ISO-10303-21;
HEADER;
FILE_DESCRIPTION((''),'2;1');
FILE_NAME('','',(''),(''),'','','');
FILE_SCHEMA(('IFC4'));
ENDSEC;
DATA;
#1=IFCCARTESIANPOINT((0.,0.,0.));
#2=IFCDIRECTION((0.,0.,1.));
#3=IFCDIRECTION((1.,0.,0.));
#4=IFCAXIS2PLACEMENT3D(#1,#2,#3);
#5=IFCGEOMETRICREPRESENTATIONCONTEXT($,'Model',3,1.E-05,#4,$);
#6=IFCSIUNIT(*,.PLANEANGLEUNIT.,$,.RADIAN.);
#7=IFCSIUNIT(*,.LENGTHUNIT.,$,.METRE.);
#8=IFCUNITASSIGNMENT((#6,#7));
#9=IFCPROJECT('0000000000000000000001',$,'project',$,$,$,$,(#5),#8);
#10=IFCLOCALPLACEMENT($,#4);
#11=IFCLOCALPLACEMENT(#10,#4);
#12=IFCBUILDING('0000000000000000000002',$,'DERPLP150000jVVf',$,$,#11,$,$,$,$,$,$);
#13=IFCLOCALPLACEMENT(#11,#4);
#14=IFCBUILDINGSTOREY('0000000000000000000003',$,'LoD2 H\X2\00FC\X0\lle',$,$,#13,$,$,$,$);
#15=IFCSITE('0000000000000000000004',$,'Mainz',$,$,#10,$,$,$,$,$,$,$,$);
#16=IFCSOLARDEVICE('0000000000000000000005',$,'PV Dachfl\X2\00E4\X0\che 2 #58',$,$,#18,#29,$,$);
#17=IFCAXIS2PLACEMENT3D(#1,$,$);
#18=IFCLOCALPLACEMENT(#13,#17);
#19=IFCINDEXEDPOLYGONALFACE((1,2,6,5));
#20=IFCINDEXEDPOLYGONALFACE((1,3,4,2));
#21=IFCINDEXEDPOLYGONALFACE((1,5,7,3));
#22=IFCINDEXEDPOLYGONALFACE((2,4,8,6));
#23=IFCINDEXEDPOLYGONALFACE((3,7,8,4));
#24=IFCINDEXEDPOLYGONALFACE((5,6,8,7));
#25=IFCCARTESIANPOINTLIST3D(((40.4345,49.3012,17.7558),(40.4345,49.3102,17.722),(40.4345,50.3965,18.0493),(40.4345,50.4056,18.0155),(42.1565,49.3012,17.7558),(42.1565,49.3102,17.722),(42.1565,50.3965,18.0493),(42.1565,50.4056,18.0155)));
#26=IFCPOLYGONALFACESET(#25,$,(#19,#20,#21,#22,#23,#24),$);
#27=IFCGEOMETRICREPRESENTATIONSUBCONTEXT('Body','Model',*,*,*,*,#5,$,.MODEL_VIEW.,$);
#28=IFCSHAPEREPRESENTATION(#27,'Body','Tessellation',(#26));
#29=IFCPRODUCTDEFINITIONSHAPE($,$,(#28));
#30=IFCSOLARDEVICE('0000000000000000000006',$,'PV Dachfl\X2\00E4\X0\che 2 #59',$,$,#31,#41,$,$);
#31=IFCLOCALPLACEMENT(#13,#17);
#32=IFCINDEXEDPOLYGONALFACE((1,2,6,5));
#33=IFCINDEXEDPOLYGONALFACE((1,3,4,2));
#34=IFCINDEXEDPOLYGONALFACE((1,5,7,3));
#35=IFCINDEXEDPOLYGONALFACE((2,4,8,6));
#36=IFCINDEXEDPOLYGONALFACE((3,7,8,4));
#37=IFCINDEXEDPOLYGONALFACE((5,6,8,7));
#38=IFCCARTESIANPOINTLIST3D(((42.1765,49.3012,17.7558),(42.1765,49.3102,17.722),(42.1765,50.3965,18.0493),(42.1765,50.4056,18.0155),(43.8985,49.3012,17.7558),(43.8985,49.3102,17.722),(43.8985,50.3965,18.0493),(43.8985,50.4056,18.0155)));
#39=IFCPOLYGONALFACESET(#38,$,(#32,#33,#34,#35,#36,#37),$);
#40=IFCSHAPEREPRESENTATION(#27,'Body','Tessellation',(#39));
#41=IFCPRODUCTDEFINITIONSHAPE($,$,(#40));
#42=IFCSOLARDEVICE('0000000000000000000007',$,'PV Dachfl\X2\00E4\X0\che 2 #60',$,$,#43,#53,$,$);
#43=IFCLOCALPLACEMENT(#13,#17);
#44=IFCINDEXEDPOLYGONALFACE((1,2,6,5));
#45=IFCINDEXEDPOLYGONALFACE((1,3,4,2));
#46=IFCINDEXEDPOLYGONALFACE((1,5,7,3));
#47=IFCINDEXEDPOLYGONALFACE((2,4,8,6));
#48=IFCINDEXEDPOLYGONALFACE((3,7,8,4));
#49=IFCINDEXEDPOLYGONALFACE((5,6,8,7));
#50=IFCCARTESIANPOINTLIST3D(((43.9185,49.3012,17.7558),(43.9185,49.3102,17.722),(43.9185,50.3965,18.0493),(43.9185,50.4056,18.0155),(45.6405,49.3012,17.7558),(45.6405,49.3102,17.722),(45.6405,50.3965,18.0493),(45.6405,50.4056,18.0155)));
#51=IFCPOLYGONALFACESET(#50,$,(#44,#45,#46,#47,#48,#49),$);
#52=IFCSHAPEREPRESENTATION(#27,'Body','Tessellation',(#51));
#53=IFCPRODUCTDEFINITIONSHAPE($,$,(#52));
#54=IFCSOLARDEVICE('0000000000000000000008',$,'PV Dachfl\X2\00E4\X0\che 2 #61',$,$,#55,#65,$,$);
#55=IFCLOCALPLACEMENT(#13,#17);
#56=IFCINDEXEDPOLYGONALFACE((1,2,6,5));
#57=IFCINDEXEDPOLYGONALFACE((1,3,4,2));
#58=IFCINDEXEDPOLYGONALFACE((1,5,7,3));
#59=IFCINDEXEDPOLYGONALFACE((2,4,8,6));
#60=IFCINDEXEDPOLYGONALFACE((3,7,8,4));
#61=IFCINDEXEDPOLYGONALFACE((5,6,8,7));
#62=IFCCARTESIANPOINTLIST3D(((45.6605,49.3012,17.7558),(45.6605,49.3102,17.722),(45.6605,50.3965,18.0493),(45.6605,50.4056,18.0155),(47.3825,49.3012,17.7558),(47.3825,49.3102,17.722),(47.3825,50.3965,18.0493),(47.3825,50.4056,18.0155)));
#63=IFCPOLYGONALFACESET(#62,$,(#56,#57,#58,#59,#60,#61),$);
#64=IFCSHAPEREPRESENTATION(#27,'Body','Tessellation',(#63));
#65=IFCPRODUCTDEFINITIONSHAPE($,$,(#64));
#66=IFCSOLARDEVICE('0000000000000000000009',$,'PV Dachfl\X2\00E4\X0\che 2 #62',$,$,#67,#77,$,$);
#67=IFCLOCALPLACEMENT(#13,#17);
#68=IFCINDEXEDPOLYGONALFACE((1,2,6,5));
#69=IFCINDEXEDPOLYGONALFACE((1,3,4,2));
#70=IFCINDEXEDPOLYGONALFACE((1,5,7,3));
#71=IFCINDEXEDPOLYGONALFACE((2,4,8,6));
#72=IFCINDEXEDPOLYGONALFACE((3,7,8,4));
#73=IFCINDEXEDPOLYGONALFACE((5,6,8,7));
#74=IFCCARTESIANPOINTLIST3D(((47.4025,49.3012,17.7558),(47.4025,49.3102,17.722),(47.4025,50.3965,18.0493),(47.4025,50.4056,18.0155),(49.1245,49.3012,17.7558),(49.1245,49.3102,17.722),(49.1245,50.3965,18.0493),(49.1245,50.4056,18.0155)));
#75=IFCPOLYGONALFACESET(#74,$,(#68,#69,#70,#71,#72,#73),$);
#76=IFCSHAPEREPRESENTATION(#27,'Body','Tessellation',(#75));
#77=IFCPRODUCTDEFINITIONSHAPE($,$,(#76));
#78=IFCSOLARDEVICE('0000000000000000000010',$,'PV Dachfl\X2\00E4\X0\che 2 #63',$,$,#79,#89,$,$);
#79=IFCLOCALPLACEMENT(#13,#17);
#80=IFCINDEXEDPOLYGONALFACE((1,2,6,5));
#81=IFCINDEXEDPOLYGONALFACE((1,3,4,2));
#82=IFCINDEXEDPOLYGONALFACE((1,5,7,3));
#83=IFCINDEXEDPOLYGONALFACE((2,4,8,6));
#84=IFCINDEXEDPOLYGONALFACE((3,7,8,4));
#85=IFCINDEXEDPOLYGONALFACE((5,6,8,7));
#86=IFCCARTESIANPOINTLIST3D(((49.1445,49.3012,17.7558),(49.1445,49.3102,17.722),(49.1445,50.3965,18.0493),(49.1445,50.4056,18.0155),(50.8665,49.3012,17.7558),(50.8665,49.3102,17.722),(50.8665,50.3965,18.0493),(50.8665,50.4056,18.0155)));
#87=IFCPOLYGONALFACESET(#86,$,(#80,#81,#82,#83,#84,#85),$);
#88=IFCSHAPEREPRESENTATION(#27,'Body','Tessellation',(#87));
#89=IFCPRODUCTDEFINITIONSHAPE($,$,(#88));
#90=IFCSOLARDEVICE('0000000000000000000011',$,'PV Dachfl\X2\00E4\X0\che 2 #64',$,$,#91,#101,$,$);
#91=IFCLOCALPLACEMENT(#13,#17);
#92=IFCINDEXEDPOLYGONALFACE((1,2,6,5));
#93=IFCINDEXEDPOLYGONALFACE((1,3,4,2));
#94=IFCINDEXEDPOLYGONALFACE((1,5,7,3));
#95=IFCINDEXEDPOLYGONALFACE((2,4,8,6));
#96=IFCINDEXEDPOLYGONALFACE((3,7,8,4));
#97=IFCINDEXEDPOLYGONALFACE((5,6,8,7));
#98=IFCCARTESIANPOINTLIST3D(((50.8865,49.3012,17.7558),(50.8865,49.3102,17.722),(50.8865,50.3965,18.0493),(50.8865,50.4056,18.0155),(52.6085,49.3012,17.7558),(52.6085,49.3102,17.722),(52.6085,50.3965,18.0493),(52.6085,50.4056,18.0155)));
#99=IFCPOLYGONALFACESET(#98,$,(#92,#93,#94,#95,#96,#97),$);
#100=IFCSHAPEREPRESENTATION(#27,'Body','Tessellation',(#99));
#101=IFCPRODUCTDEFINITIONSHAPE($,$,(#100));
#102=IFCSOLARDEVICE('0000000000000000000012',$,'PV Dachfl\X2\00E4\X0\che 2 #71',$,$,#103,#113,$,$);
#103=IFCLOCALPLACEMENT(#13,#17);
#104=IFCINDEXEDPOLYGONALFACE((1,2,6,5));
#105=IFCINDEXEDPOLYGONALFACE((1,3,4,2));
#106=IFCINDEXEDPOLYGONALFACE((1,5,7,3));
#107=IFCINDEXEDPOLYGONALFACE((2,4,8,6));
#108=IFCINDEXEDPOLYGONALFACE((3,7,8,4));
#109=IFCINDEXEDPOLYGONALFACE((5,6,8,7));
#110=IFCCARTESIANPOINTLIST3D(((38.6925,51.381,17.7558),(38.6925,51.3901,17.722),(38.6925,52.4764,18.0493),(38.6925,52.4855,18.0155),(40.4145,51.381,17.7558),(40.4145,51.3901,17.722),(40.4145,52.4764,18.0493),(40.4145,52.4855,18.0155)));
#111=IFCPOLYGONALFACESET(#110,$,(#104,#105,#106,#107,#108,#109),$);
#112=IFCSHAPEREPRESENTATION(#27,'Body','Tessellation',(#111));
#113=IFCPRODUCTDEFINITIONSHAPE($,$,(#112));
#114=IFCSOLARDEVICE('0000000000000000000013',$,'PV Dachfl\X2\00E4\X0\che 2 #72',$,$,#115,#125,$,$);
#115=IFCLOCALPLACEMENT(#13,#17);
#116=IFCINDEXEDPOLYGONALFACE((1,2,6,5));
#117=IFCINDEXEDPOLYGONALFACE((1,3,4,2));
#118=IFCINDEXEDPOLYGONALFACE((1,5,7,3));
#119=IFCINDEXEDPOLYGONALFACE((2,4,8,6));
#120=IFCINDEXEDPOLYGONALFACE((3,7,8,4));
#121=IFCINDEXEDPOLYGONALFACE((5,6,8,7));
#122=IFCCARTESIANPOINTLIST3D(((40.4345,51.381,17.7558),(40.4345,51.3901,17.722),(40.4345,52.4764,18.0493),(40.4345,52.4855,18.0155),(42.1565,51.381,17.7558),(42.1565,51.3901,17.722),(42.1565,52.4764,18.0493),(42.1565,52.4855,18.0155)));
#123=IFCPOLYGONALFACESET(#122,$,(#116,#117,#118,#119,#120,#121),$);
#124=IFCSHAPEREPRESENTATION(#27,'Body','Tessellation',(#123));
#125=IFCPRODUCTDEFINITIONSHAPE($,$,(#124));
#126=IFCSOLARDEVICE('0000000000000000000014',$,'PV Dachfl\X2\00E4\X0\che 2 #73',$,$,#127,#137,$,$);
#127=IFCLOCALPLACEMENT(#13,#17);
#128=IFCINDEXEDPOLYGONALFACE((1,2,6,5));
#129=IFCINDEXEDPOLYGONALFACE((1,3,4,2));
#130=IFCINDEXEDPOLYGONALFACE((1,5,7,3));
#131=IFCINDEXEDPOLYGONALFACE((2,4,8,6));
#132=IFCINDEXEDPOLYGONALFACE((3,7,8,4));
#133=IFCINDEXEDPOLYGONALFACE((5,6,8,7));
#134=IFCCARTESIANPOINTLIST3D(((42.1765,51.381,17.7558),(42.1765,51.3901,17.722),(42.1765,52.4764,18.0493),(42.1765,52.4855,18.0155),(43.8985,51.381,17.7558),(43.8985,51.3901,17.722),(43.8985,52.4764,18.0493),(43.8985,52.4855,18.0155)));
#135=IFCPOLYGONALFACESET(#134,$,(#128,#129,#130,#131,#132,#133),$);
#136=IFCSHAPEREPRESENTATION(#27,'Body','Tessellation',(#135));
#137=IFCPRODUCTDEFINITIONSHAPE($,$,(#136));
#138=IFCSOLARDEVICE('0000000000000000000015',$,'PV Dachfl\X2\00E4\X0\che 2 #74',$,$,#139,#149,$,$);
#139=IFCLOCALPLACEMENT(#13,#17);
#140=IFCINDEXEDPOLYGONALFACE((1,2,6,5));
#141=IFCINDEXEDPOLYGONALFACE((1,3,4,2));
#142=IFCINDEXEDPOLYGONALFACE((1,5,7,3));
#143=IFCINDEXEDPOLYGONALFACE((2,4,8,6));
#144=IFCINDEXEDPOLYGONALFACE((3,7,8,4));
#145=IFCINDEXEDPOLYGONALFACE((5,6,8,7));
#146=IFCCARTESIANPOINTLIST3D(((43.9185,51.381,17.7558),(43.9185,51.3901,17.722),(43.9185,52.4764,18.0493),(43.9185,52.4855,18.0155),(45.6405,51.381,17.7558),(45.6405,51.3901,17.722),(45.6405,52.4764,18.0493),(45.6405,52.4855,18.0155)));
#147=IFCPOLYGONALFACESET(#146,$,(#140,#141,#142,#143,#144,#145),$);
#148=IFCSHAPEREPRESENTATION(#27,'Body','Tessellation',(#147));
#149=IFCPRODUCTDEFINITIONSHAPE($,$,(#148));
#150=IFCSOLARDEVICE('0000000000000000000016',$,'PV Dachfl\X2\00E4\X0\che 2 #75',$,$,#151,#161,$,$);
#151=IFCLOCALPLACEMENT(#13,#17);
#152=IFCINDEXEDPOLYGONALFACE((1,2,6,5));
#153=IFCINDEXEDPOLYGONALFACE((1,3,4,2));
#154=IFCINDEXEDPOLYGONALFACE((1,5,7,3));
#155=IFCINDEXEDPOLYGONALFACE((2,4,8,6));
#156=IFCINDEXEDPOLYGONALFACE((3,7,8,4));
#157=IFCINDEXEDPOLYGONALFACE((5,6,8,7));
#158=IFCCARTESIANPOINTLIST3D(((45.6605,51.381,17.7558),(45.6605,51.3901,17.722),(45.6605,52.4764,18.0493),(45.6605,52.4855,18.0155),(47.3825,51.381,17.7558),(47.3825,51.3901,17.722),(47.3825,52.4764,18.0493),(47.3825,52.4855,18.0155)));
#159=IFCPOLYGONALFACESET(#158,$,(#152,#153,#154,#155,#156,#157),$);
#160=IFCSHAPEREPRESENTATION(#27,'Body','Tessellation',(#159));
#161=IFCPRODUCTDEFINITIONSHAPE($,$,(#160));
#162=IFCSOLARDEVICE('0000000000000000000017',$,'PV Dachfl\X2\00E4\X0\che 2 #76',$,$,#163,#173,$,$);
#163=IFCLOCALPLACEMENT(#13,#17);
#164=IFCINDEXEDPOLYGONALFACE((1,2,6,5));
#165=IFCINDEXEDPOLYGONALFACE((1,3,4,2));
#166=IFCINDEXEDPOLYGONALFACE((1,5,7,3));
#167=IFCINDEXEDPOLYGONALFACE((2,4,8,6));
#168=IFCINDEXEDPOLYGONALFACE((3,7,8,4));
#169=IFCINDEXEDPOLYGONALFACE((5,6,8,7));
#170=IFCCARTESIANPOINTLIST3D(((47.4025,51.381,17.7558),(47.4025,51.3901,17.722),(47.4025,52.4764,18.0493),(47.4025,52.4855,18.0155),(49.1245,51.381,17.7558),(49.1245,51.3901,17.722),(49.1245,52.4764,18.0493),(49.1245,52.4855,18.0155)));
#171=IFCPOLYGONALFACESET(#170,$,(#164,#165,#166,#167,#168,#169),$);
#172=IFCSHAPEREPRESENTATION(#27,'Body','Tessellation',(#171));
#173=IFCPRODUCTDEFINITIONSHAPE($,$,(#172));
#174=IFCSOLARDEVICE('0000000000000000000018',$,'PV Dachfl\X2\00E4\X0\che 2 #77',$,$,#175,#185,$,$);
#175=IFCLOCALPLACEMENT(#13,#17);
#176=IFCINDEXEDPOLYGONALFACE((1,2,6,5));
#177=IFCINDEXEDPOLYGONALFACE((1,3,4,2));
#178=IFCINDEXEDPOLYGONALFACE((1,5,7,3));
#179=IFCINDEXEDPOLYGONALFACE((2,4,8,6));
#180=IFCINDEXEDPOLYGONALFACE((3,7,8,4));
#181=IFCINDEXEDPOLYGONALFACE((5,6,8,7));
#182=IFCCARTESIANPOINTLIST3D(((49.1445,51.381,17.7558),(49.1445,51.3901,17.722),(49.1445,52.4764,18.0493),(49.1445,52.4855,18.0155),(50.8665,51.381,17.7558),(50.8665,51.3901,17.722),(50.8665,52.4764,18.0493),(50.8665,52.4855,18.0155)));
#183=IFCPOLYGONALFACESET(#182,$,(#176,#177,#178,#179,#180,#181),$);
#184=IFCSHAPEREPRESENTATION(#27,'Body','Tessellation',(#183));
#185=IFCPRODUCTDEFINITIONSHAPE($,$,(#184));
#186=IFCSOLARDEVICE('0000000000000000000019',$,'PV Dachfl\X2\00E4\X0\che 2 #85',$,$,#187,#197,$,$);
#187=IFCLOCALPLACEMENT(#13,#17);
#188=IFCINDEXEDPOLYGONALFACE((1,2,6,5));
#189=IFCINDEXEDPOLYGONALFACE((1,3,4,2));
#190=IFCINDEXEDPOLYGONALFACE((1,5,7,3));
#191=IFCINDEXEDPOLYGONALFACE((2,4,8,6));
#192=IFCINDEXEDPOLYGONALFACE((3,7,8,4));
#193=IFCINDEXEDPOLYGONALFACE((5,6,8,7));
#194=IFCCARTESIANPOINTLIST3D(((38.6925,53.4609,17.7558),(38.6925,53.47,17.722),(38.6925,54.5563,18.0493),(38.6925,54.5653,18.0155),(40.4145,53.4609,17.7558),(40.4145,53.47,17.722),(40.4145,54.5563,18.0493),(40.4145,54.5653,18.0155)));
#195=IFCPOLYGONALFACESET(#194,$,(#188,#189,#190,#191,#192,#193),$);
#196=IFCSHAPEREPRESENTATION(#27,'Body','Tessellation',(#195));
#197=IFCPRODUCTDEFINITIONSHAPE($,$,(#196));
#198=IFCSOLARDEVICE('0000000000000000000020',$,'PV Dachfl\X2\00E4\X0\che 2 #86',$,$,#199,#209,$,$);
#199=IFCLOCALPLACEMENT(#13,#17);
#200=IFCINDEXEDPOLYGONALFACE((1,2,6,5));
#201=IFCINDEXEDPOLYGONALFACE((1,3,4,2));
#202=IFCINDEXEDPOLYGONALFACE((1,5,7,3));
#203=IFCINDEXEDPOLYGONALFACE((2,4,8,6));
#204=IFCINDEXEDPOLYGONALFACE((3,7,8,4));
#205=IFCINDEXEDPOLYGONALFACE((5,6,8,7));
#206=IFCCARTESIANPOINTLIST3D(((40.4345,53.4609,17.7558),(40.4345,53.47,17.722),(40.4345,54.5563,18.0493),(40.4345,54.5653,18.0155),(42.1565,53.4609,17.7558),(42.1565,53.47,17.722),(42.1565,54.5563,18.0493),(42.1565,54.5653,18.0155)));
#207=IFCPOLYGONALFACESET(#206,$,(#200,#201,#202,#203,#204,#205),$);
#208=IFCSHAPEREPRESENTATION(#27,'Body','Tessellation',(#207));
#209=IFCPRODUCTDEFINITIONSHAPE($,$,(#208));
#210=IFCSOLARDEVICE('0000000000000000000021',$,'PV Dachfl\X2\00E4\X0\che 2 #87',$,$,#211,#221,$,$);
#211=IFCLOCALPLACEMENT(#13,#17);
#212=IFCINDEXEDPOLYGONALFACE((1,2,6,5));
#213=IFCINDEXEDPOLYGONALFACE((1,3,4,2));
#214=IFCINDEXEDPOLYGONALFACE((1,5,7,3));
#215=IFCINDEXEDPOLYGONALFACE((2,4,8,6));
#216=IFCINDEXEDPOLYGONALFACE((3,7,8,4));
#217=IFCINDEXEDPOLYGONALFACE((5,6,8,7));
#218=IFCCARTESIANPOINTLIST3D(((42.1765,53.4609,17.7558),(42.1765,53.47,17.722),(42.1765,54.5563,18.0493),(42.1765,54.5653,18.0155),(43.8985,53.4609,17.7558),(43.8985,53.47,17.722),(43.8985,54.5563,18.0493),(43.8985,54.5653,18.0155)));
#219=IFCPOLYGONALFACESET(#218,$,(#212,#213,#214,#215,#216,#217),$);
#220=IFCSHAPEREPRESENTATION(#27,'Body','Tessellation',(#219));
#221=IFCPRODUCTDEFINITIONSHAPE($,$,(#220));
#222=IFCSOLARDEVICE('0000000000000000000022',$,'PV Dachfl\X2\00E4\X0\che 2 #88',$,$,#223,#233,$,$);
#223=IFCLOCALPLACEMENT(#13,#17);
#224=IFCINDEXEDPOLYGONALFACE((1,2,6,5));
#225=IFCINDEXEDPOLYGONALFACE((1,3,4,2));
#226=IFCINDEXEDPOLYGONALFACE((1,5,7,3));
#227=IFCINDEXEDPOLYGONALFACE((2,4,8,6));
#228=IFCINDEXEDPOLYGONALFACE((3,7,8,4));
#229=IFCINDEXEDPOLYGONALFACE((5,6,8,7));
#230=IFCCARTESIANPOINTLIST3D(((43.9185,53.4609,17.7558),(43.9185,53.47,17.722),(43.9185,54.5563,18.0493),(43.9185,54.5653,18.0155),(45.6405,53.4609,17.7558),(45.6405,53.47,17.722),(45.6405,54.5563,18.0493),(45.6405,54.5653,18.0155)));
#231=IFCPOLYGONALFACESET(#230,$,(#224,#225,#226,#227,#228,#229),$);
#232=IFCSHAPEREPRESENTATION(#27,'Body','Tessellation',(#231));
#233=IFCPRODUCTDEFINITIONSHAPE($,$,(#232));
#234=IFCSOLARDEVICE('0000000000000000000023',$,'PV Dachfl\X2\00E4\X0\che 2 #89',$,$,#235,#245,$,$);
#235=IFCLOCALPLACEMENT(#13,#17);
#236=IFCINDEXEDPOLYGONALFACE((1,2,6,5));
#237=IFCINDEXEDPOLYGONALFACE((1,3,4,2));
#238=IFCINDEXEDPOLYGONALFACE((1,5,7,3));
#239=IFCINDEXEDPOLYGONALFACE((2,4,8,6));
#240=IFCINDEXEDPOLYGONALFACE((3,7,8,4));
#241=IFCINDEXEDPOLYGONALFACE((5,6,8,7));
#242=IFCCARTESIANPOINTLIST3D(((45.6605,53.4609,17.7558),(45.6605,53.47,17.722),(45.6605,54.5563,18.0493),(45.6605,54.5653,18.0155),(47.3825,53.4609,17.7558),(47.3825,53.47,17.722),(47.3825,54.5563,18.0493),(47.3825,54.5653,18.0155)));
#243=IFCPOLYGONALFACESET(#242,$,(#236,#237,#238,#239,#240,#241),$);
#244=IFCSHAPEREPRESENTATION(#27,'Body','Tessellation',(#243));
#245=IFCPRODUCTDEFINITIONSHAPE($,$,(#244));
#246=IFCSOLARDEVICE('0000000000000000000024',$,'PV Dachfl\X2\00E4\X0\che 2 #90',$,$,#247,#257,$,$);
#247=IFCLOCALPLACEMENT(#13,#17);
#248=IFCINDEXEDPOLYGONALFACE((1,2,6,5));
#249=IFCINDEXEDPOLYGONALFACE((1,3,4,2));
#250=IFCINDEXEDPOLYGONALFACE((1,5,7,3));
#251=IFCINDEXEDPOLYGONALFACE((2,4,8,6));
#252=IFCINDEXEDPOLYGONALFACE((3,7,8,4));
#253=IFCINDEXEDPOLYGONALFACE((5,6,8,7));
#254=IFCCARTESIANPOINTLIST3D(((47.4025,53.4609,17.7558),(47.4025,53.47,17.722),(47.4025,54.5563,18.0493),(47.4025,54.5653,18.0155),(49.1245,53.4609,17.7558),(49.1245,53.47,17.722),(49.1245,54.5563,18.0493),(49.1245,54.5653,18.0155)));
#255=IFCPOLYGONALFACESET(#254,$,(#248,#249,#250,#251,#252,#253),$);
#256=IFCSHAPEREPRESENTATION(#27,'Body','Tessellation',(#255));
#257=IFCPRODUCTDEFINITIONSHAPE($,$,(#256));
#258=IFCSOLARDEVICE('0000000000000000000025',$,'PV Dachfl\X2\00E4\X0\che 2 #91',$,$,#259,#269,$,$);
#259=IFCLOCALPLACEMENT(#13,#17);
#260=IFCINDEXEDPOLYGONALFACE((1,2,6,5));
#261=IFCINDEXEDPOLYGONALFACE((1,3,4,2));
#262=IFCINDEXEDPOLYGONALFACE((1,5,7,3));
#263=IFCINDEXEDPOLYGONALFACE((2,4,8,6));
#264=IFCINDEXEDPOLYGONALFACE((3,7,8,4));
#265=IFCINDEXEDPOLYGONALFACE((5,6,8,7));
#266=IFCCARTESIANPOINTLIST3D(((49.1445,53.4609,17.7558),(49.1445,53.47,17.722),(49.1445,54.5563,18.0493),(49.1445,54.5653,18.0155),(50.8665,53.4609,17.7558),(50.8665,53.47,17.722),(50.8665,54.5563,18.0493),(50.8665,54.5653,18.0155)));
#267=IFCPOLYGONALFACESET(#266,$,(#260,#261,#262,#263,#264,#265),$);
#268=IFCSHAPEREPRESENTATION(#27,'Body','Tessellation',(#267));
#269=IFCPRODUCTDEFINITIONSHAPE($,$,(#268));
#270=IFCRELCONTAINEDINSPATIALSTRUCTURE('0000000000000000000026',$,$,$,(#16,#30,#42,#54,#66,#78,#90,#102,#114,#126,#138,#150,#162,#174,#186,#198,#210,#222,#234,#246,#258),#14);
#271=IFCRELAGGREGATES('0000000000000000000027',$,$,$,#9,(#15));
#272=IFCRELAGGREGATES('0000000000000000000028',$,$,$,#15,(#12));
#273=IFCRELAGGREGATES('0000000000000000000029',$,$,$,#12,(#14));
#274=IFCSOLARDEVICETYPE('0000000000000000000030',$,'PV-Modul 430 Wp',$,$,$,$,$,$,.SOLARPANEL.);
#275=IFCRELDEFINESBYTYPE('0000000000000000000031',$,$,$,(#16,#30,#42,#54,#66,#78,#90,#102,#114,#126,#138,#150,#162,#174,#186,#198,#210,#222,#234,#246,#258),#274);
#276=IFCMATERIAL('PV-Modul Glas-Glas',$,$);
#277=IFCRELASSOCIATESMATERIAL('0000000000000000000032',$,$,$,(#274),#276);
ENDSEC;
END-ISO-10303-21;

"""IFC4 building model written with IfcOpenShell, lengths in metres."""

from ifc_helpers import new_model, si_unit, frame, frame_2d, origin, origin_with_axes, place, context, subcontext, project, spatial, rectangle, extrude, source, transform, mapped, material, type_object, type_shapes, element, save


model = new_model("IFC4")

# Units and contexts
model_context = context("Model", 3, precision=1e-05, world=origin_with_axes())
body_context = subcontext(model_context, "Body", "Model", "MODEL_VIEW")
ifc_project = project(units=[si_unit("PLANEANGLEUNIT", "RADIAN"), si_unit("LENGTHUNIT", "METRE")], contexts=[model_context])

# Site, building, storey
site_placement = place(None, origin_with_axes())
site = spatial("IfcSite", under=ifc_project, at=site_placement, Name="Mainz")
building_placement = place(site_placement, origin_with_axes())
building = spatial("IfcBuilding", under=site, at=building_placement, Name="DERPLP150000jVVf")
storey_placement = place(building_placement, origin_with_axes())
storey = spatial("IfcBuildingStorey", under=building, at=storey_placement, Name="LoD2 Hülle")

# Solar devices
ifc_material = material(Name="PV-Modul Glas-Glas")
solar_device_type = type_object("IfcSolarDeviceType", Name="PV-Modul 430 Wp", PredefinedType="SOLARPANEL", material=ifc_material)
shared_shape = source(origin_with_axes(), body_context, "Body", "SweptSolid", [
    extrude(rectangle(XDim=1.722, YDim=1.134, at=frame_2d((0.861, 0.567))), origin(), (0.0, 0.0, 1.0), 0.035),
])
type_shapes(solar_device_type, [shared_shape])
for number, where, z_axis, x_axis, name in (
    (1, (40.4345, 49.3102, 17.722), (0.0, -0.258819, 0.965926), (1.0, 0.0, 0.0), "PV Dachfläche 2 #58"),
    (2, (42.1765, 49.3102, 17.722), (0.0, -0.258819, 0.965926), (1.0, 0.0, 0.0), "PV Dachfläche 2 #59"),
    (3, (43.9185, 49.3102, 17.722), (0.0, -0.258819, 0.965926), (1.0, 0.0, 0.0), "PV Dachfläche 2 #60"),
    (4, (45.6605, 49.3102, 17.722), (0.0, -0.258819, 0.965926), (1.0, 0.0, 0.0), "PV Dachfläche 2 #61"),
    (5, (47.4025, 49.3102, 17.722), (0.0, -0.258819, 0.965926), (1.0, 0.0, 0.0), "PV Dachfläche 2 #62"),
    (6, (49.1445, 49.3102, 17.722), (0.0, -0.258819, 0.965926), (1.0, 0.0, 0.0), "PV Dachfläche 2 #63"),
    (7, (50.8865, 49.3102, 17.722), (0.0, -0.258819, 0.965926), (1.0, 0.0, 0.0), "PV Dachfläche 2 #64"),
    (8, (38.6925, 51.3901, 17.722), (0.0, -0.258819, 0.965926), (1.0, 0.0, 0.0), "PV Dachfläche 2 #71"),
    (9, (40.4345, 51.3901, 17.722), (0.0, -0.258819, 0.965926), (1.0, 0.0, 0.0), "PV Dachfläche 2 #72"),
    (10, (42.1765, 51.3901, 17.722), (0.0, -0.258819, 0.965926), (1.0, 0.0, 0.0), "PV Dachfläche 2 #73"),
    (11, (43.9185, 51.3901, 17.722), (0.0, -0.258819, 0.965926), (1.0, 0.0, 0.0), "PV Dachfläche 2 #74"),
    (12, (45.6605, 51.3901, 17.722), (0.0, -0.258819, 0.965926), (1.0, 0.0, 0.0), "PV Dachfläche 2 #75"),
    (13, (47.4025, 51.3901, 17.722), (0.0, -0.258819, 0.965926), (1.0, 0.0, 0.0), "PV Dachfläche 2 #76"),
    (14, (49.1445, 51.3901, 17.722), (0.0, -0.258819, 0.965926), (1.0, 0.0, 0.0), "PV Dachfläche 2 #77"),
    (15, (38.6925, 53.47, 17.722), (0.0, -0.258819, 0.965926), (1.0, 0.0, 0.0), "PV Dachfläche 2 #85"),
    (16, (40.4345, 53.47, 17.722), (0.0, -0.258819, 0.965926), (1.0, 0.0, 0.0), "PV Dachfläche 2 #86"),
    (17, (42.1765, 53.47, 17.722), (0.0, -0.258819, 0.965926), (1.0, 0.0, 0.0), "PV Dachfläche 2 #87"),
    (18, (43.9185, 53.47, 17.722), (0.0, -0.258819, 0.965926), (1.0, 0.0, 0.0), "PV Dachfläche 2 #88"),
    (19, (45.6605, 53.47, 17.722), (0.0, -0.258819, 0.965926), (1.0, 0.0, 0.0), "PV Dachfläche 2 #89"),
    (20, (47.4025, 53.47, 17.722), (0.0, -0.258819, 0.965926), (1.0, 0.0, 0.0), "PV Dachfläche 2 #90"),
    (21, (49.1445, 53.47, 17.722), (0.0, -0.258819, 0.965926), (1.0, 0.0, 0.0), "PV Dachfläche 2 #91"),
):
    element("IfcSolarDevice", number, at=place(storey_placement, frame(where, z_axis=z_axis, x_axis=x_axis)), inside=storey, type_object=solar_device_type, Name=name, context=body_context, shape_type="MappedRepresentation", body=[
        mapped(shared_shape, transform((0.0, 0.0, 0.0), x_axis=(1.0, 0.0, 0.0), y_axis=(0.0, 1.0, 0.0), z_axis=(0.0, 0.0, 1.0), scale=1.0)),
    ])

save(model, "model.ifc")
